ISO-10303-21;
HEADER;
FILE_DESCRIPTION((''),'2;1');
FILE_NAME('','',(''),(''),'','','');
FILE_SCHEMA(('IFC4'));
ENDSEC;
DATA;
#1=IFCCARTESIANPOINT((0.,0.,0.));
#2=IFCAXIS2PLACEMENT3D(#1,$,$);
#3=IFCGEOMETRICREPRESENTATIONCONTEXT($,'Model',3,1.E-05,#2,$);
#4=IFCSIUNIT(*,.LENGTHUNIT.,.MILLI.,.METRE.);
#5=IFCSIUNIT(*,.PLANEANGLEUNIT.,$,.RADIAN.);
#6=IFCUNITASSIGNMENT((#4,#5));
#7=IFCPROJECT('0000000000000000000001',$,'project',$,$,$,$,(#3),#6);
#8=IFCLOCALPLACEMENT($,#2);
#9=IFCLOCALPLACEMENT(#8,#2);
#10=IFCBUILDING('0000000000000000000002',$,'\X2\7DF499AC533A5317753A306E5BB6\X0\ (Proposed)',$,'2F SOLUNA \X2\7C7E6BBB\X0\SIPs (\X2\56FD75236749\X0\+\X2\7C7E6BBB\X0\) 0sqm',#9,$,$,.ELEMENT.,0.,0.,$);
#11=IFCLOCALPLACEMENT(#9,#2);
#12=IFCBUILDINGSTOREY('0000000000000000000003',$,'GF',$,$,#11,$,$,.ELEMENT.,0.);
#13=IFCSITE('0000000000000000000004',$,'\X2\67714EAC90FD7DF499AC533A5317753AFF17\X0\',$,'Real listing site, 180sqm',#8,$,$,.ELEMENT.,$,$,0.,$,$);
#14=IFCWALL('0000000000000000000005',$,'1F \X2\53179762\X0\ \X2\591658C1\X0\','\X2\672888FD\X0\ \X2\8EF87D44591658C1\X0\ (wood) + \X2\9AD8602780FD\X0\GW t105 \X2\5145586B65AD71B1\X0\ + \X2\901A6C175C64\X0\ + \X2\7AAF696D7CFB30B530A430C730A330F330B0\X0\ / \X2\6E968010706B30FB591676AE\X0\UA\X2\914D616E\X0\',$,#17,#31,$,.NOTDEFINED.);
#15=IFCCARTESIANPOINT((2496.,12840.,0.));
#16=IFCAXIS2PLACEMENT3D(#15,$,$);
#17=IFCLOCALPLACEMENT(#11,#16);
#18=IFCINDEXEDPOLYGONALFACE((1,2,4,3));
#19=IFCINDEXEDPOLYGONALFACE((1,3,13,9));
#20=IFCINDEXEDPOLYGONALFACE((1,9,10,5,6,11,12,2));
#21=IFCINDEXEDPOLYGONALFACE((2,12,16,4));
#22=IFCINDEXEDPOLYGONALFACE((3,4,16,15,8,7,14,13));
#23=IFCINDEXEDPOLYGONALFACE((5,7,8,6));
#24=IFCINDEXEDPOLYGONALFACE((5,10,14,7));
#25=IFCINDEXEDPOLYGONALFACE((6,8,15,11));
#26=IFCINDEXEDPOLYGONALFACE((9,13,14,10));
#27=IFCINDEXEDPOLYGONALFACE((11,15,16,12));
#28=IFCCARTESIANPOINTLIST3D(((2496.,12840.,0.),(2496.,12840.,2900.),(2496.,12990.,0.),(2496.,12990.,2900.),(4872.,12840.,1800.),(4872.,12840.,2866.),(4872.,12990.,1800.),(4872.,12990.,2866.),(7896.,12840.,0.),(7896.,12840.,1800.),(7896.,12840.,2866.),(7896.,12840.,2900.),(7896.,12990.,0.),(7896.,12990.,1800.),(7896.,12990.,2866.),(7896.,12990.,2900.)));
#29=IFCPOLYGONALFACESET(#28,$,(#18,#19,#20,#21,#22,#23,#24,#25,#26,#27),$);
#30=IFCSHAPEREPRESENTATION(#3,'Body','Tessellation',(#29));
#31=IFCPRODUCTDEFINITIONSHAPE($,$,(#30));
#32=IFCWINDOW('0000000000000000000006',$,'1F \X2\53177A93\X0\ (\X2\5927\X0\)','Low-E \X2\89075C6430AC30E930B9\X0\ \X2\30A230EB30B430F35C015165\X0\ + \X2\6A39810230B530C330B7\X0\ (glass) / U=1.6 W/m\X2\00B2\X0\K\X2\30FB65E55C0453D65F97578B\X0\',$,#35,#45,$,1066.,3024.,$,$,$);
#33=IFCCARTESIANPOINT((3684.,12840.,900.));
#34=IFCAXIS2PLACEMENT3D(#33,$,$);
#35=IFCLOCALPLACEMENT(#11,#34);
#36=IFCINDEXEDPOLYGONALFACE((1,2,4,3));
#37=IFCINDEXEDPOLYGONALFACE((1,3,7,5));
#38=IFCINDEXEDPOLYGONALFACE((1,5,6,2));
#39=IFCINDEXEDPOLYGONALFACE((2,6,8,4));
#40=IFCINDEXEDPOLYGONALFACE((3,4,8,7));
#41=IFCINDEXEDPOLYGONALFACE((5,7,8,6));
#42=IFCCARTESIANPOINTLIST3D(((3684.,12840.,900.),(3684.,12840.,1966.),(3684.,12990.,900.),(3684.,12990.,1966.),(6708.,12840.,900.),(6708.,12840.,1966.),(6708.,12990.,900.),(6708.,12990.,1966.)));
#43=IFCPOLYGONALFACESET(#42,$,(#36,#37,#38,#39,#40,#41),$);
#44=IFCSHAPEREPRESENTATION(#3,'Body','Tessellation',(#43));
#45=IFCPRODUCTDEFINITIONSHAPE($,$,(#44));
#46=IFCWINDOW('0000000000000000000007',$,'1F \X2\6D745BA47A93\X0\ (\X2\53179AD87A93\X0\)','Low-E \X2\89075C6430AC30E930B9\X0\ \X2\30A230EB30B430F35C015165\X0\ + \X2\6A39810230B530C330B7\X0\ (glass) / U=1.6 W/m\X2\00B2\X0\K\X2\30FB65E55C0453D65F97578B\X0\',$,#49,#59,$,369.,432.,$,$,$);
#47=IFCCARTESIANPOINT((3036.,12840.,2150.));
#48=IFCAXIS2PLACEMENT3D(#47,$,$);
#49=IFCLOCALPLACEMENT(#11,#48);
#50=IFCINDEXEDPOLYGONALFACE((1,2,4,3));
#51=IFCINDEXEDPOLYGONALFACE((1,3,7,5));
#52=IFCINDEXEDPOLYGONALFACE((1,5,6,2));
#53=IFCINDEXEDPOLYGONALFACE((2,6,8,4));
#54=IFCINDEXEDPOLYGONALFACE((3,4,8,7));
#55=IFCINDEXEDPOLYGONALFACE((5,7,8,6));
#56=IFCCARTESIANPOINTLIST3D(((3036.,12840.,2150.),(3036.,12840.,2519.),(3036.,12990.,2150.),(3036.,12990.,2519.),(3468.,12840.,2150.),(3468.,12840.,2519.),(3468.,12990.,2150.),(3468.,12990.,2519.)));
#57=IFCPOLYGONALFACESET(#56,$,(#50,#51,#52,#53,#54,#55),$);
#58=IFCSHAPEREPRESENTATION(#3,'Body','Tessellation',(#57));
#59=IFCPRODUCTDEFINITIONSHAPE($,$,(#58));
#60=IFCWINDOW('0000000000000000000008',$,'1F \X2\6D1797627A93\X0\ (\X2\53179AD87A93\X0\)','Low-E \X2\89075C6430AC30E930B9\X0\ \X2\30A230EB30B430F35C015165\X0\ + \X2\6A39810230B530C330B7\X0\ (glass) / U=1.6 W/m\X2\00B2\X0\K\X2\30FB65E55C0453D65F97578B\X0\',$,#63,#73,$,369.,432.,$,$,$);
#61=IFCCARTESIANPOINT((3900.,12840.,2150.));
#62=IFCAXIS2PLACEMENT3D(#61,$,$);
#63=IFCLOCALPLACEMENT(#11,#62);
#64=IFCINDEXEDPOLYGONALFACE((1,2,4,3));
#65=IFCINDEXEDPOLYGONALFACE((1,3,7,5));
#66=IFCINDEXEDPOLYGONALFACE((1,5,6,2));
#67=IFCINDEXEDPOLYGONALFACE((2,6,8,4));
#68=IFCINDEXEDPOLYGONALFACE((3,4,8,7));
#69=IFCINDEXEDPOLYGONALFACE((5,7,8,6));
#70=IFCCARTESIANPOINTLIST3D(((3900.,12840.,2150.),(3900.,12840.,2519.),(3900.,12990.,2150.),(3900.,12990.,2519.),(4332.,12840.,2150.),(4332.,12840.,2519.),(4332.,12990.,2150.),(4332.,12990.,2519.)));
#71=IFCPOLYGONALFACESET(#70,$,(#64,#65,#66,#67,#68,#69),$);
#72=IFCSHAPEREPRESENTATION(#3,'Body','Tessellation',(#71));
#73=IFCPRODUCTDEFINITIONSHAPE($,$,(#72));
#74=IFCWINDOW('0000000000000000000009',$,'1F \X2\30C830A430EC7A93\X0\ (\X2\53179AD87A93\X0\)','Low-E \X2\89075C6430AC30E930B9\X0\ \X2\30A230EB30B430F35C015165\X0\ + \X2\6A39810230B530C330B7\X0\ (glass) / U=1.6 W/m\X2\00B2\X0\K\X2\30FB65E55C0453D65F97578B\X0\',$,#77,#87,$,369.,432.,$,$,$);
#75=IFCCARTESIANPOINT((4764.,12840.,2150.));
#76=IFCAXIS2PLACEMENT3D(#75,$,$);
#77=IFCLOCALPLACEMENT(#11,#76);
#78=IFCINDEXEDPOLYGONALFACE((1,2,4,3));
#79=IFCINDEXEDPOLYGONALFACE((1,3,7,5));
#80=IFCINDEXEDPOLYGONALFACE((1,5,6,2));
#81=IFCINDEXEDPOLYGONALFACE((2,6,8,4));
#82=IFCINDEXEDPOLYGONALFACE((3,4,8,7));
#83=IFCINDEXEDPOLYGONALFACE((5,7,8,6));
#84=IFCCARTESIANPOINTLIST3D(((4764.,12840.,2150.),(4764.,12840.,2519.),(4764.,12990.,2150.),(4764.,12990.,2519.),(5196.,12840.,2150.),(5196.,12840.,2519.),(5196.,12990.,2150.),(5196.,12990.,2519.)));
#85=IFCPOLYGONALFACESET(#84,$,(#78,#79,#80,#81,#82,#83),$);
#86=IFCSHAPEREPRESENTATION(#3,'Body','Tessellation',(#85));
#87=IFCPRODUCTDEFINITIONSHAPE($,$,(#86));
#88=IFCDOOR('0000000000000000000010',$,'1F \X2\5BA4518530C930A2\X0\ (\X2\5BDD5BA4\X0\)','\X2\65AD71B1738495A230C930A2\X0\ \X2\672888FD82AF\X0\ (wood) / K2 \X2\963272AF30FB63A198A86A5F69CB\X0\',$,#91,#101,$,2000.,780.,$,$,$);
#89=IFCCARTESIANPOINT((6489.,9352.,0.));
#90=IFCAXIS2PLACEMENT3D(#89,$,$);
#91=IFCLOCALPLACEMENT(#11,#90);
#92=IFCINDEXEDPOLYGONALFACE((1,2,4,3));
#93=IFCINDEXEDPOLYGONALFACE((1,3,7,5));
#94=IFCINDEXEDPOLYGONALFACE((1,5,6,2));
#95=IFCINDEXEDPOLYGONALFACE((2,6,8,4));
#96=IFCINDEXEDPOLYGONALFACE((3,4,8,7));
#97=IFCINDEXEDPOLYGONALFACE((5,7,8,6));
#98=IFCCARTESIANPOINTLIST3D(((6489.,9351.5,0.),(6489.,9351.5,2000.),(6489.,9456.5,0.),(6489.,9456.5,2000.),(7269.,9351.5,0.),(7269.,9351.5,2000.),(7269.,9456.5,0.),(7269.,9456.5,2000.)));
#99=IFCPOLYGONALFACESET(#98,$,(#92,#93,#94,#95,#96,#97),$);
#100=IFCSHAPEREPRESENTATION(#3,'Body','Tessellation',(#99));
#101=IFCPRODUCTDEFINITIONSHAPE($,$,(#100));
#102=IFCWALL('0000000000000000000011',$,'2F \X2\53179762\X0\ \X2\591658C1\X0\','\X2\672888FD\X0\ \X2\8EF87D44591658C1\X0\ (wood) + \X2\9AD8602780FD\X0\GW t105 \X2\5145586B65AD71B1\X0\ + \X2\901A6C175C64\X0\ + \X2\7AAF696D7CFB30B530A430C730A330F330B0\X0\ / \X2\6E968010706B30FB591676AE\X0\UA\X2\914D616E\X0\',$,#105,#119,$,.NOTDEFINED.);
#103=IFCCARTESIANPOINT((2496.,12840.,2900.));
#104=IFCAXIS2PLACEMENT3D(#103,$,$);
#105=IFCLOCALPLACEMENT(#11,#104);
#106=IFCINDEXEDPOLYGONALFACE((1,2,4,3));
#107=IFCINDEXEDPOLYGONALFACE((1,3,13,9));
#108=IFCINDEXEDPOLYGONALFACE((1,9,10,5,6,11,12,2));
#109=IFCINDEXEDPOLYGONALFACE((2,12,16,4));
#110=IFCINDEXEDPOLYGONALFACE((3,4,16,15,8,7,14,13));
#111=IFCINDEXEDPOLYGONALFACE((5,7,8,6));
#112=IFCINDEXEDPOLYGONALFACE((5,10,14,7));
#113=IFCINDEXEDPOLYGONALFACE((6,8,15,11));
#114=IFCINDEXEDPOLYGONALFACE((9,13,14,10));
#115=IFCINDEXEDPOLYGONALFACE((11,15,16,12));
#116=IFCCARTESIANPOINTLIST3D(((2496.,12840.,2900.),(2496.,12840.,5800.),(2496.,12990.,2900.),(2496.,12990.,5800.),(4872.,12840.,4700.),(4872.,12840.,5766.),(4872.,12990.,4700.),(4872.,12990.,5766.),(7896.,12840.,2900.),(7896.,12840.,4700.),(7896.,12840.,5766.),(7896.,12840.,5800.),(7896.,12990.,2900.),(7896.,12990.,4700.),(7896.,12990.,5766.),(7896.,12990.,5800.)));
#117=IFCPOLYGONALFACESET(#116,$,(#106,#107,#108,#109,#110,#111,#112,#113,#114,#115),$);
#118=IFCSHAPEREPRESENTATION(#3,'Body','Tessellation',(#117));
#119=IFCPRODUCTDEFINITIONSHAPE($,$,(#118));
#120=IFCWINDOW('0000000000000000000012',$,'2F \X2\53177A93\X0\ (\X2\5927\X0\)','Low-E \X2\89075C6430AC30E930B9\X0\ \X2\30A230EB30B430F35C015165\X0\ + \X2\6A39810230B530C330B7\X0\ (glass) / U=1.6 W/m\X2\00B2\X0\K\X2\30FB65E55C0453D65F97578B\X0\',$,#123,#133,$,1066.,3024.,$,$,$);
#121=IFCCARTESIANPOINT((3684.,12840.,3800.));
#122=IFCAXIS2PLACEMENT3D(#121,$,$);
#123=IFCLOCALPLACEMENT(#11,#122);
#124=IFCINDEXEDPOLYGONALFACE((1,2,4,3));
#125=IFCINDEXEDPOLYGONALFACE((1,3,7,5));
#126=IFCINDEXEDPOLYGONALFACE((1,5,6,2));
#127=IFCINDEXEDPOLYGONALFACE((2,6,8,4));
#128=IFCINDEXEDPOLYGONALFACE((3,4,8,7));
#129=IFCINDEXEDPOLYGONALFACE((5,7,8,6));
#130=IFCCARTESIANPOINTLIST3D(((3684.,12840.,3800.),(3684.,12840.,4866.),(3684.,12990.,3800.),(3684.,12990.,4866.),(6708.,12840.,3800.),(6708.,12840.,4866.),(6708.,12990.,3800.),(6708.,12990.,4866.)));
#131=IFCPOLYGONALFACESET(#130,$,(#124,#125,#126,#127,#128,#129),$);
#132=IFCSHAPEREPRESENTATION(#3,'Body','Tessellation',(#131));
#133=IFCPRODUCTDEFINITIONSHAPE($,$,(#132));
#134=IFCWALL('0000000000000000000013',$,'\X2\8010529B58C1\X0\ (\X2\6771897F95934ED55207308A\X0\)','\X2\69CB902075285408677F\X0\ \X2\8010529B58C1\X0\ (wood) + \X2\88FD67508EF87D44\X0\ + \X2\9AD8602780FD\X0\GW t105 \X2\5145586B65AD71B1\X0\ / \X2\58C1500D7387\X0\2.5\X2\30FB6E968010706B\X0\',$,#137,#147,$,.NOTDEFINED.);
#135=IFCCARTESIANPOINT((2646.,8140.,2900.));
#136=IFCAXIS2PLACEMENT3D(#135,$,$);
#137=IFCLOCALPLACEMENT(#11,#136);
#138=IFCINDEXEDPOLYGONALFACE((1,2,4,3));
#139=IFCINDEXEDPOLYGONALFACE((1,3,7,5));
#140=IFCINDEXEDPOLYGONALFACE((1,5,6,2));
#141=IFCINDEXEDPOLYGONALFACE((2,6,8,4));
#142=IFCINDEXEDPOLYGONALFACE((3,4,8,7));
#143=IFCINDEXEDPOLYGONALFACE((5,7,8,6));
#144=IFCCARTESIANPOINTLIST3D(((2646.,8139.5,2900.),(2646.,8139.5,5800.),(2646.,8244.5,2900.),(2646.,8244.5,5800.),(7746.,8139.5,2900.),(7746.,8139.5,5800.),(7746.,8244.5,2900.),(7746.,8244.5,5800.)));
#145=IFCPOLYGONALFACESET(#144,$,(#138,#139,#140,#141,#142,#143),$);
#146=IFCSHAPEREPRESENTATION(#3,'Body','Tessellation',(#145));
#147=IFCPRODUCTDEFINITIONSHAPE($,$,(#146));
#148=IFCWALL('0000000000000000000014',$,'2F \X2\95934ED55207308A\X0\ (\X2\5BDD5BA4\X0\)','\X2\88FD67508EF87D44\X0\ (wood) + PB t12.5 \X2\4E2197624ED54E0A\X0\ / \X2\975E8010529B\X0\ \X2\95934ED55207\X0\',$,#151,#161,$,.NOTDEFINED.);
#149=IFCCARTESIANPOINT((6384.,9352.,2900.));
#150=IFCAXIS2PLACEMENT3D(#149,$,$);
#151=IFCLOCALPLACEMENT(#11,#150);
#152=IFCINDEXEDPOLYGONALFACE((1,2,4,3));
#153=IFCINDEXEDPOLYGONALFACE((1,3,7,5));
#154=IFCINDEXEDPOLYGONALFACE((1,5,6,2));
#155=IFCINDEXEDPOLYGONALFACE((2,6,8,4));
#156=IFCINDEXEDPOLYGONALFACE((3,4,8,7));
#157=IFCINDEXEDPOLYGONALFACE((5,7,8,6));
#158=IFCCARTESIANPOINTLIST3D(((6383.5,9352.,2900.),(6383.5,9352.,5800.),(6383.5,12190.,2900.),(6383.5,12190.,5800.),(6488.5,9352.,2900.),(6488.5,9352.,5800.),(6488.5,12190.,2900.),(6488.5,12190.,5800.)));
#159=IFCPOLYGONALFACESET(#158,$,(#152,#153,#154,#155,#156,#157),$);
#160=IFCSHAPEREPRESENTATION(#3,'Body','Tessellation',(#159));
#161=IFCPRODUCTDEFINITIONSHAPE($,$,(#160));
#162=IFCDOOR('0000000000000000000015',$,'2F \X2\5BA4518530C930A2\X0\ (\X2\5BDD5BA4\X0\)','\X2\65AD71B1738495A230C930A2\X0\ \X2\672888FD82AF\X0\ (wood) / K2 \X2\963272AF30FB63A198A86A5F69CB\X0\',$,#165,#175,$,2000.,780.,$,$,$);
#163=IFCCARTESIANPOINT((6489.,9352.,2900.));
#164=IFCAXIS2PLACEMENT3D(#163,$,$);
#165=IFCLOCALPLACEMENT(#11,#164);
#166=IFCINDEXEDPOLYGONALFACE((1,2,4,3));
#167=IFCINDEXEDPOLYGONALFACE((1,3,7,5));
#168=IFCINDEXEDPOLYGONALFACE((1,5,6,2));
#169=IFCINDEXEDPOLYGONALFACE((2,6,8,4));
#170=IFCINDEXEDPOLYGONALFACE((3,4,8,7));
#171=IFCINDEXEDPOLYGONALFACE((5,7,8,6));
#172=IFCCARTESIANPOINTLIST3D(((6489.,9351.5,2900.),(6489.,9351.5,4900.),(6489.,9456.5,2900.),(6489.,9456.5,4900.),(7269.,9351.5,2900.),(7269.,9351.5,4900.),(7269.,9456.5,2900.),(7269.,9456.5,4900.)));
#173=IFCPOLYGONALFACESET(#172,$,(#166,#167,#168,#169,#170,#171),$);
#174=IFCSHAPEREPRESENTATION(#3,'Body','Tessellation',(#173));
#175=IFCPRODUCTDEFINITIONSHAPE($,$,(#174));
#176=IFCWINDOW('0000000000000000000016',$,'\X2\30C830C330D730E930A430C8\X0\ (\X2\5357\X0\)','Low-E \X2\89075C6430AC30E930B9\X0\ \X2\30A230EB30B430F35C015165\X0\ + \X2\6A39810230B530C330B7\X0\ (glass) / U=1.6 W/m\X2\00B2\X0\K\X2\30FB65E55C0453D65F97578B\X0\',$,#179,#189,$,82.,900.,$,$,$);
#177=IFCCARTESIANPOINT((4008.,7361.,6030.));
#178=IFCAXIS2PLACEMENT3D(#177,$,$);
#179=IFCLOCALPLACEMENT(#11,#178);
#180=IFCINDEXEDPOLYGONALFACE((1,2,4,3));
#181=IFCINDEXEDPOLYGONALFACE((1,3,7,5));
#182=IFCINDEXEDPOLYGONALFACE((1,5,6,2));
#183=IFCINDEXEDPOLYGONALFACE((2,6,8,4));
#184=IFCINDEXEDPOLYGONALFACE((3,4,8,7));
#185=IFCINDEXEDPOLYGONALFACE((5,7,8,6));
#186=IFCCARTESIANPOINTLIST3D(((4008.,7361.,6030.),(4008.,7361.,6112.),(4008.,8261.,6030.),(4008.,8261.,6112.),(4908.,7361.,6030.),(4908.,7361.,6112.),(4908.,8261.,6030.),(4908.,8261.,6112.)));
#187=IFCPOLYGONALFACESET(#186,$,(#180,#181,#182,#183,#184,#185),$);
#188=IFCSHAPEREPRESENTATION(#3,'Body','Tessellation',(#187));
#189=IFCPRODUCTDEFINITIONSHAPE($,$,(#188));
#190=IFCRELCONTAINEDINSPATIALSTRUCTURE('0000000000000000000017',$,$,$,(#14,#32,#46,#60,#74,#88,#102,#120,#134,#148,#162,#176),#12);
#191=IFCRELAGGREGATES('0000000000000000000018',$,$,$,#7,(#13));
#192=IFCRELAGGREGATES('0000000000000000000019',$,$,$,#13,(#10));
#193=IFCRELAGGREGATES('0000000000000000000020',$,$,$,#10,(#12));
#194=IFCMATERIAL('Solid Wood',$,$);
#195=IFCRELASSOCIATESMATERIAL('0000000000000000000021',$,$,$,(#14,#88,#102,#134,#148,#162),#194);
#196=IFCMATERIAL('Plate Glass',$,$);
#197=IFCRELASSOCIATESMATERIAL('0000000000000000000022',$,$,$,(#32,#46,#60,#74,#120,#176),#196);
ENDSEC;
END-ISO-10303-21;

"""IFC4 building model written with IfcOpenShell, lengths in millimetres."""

from ifc_helpers import new_model, si_unit, frame, frame_2d, origin, place, context, project, spatial, rectangle, extrude, material, element, fill, save


model = new_model("IFC4")

# Units and contexts
model_context = context("Model", 3, precision=1e-05, world=origin())
ifc_project = project(units=[si_unit("LENGTHUNIT", "METRE", prefix="MILLI"), si_unit("PLANEANGLEUNIT", "RADIAN")], contexts=[model_context])

# Site, building, storey
site_placement = place(None, origin())
site = spatial("IfcSite", under=ifc_project, at=site_placement, Name="東京都練馬区北町７", ObjectType="Real listing site, 180sqm", CompositionType="ELEMENT", RefElevation=0.0)
building_placement = place(site_placement, origin())
building = spatial("IfcBuilding", under=site, at=building_placement, Name="練馬区北町の家 (Proposed)", ObjectType="2F SOLUNA 籾殻SIPs (国産杉+籾殻) 0sqm", CompositionType="ELEMENT", ElevationOfRefHeight=0.0, ElevationOfTerrain=0.0)
storey_placement = place(building_placement, origin())
storey = spatial("IfcBuildingStorey", under=building, at=storey_placement, Name="GF", CompositionType="ELEMENT", Elevation=0.0)

# Wall, openings, windows
ifc_material_1 = material(Name="Solid Wood")
wall_1_placement = place(storey_placement, frame((2496.0, 12840.0, 0.0)))
wall_1 = element("IfcWall", 1, at=wall_1_placement, inside=storey, material=ifc_material_1, Name="1F 北面 外壁", Description="木製 軸組外壁 (wood) + 高性能GW t105 充填断熱 + 通気層 + 窯業系サイディング / 準耐火・外皮UA配慮", PredefinedType="NOTDEFINED", context=model_context, shape_type="SweptSolid", body=[
    extrude(rectangle(XDim=5400.0, YDim=150.0, at=frame_2d((2700.0, 75.0))), frame((2496.0, 12840.0, 0.0)), (0.0, 0.0, 1.0), 2900.0),
])
opening_1_placement = place(storey_placement, frame((3684.0, 12840.0, 900.0)))
opening_1 = element("IfcOpeningElement", 2, at=opening_1_placement, cuts=wall_1, PredefinedType="NOTDEFINED", context=model_context, shape_type="SweptSolid", body=[
    extrude(rectangle(XDim=3024.0, YDim=150.0, at=frame_2d((1512.0, 75.0))), frame((3684.0, 12840.0, 900.0)), (0.0, 0.0, 1.0), 1066.0),
])
opening_2_placement = place(storey_placement, frame((3036.0, 12840.0, 2150.0)))
opening_2 = element("IfcOpeningElement", 3, at=opening_2_placement, cuts=wall_1, PredefinedType="NOTDEFINED", context=model_context, shape_type="SweptSolid", body=[
    extrude(rectangle(XDim=432.0, YDim=150.0, at=frame_2d((216.0, 75.0))), frame((3036.0, 12840.0, 2150.0)), (0.0, 0.0, 1.0), 369.0),
])
opening_3_placement = place(storey_placement, frame((3900.0, 12840.0, 2150.0)))
opening_3 = element("IfcOpeningElement", 4, at=opening_3_placement, cuts=wall_1, PredefinedType="NOTDEFINED", context=model_context, shape_type="SweptSolid", body=[
    extrude(rectangle(XDim=432.0, YDim=150.0, at=frame_2d((216.0, 75.0))), frame((3900.0, 12840.0, 2150.0)), (0.0, 0.0, 1.0), 369.0),
])
opening_4_placement = place(storey_placement, frame((4764.0, 12840.0, 2150.0)))
opening_4 = element("IfcOpeningElement", 5, at=opening_4_placement, cuts=wall_1, PredefinedType="NOTDEFINED", context=model_context, shape_type="SweptSolid", body=[
    extrude(rectangle(XDim=432.0, YDim=150.0, at=frame_2d((216.0, 75.0))), frame((4764.0, 12840.0, 2150.0)), (0.0, 0.0, 1.0), 369.0),
])
ifc_material_2 = material(Name="Plate Glass")
window_1_placement = place(storey_placement, frame((3684.0, 12840.0, 900.0)))
window_1 = element("IfcWindow", 6, at=window_1_placement, inside=storey, material=ifc_material_2, Name="1F 北窓 (大)", Description="Low-E 複層ガラス アルゴン封入 + 樹脂サッシ (glass) / U=1.6 W/m²K・日射取得型", OverallHeight=1066.0, OverallWidth=3024.0, context=model_context, shape_type="SweptSolid", body=[
    extrude(rectangle(XDim=3024.0, YDim=150.0, at=frame_2d((1512.0, 75.0))), frame((3684.0, 12840.0, 900.0)), (0.0, 0.0, 1.0), 1066.0),
])
fill(opening_1, window_1)
window_2_placement = place(storey_placement, frame((3036.0, 12840.0, 2150.0)))
window_2 = element("IfcWindow", 7, at=window_2_placement, inside=storey, material=ifc_material_2, Name="1F 浴室窓 (北高窓)", Description="Low-E 複層ガラス アルゴン封入 + 樹脂サッシ (glass) / U=1.6 W/m²K・日射取得型", OverallHeight=369.0, OverallWidth=432.0, context=model_context, shape_type="SweptSolid", body=[
    extrude(rectangle(XDim=432.0, YDim=150.0, at=frame_2d((216.0, 75.0))), frame((3036.0, 12840.0, 2150.0)), (0.0, 0.0, 1.0), 369.0),
])
fill(opening_2, window_2)
window_3_placement = place(storey_placement, frame((3900.0, 12840.0, 2150.0)))
window_3 = element("IfcWindow", 8, at=window_3_placement, inside=storey, material=ifc_material_2, Name="1F 洗面窓 (北高窓)", Description="Low-E 複層ガラス アルゴン封入 + 樹脂サッシ (glass) / U=1.6 W/m²K・日射取得型", OverallHeight=369.0, OverallWidth=432.0, context=model_context, shape_type="SweptSolid", body=[
    extrude(rectangle(XDim=432.0, YDim=150.0, at=frame_2d((216.0, 75.0))), frame((3900.0, 12840.0, 2150.0)), (0.0, 0.0, 1.0), 369.0),
])
fill(opening_3, window_3)
window_4_placement = place(storey_placement, frame((4764.0, 12840.0, 2150.0)))
window_4 = element("IfcWindow", 9, at=window_4_placement, inside=storey, material=ifc_material_2, Name="1F トイレ窓 (北高窓)", Description="Low-E 複層ガラス アルゴン封入 + 樹脂サッシ (glass) / U=1.6 W/m²K・日射取得型", OverallHeight=369.0, OverallWidth=432.0, context=model_context, shape_type="SweptSolid", body=[
    extrude(rectangle(XDim=432.0, YDim=150.0, at=frame_2d((216.0, 75.0))), frame((4764.0, 12840.0, 2150.0)), (0.0, 0.0, 1.0), 369.0),
])
fill(opening_4, window_4)

# Door
door_1_placement = place(storey_placement, frame((6489.0, 9352.0, 0.0)))
element("IfcDoor", 10, at=door_1_placement, inside=storey, material=ifc_material_1, Name="1F 室内ドア (寝室)", Description="断熱玄関ドア 木製芯 (wood) / K2 防犯・採風機構", OverallHeight=2000.0, OverallWidth=780.0, context=model_context, shape_type="SweptSolid", body=[
    extrude(rectangle(XDim=780.0, YDim=105.0, at=frame_2d((390.0, 52.0))), frame((6489.0, 9352.0, 0.0)), (0.0, 0.0, 1.0), 2000.0),
])

# Wall, opening, window
wall_2_placement = place(storey_placement, frame((2496.0, 12840.0, 2900.0)))
wall_2 = element("IfcWall", 11, at=wall_2_placement, inside=storey, material=ifc_material_1, Name="2F 北面 外壁", Description="木製 軸組外壁 (wood) + 高性能GW t105 充填断熱 + 通気層 + 窯業系サイディング / 準耐火・外皮UA配慮", PredefinedType="NOTDEFINED", context=model_context, shape_type="SweptSolid", body=[
    extrude(rectangle(XDim=5400.0, YDim=150.0, at=frame_2d((2700.0, 75.0))), frame((2496.0, 12840.0, 2900.0)), (0.0, 0.0, 1.0), 2900.0),
])
opening_5_placement = place(storey_placement, frame((3684.0, 12840.0, 3800.0)))
opening_5 = element("IfcOpeningElement", 12, at=opening_5_placement, cuts=wall_2, PredefinedType="NOTDEFINED", context=model_context, shape_type="SweptSolid", body=[
    extrude(rectangle(XDim=3024.0, YDim=150.0, at=frame_2d((1512.0, 75.0))), frame((3684.0, 12840.0, 3800.0)), (0.0, 0.0, 1.0), 1066.0),
])
window_5_placement = place(storey_placement, frame((3684.0, 12840.0, 3800.0)))
window_5 = element("IfcWindow", 13, at=window_5_placement, inside=storey, material=ifc_material_2, Name="2F 北窓 (大)", Description="Low-E 複層ガラス アルゴン封入 + 樹脂サッシ (glass) / U=1.6 W/m²K・日射取得型", OverallHeight=1066.0, OverallWidth=3024.0, context=model_context, shape_type="SweptSolid", body=[
    extrude(rectangle(XDim=3024.0, YDim=150.0, at=frame_2d((1512.0, 75.0))), frame((3684.0, 12840.0, 3800.0)), (0.0, 0.0, 1.0), 1066.0),
])
fill(opening_5, window_5)

# Walls
wall_3_placement = place(storey_placement, frame((2646.0, 8140.0, 2900.0)))
element("IfcWall", 14, at=wall_3_placement, inside=storey, material=ifc_material_1, Name="耐力壁 (東西間仕切り)", Description="構造用合板 耐力壁 (wood) + 製材軸組 + 高性能GW t105 充填断熱 / 壁倍率2.5・準耐火", PredefinedType="NOTDEFINED", context=model_context, shape_type="SweptSolid", body=[
    extrude(rectangle(XDim=5100.0, YDim=105.0, at=frame_2d((2550.0, 52.0))), frame((2646.0, 8140.0, 2900.0)), (0.0, 0.0, 1.0), 2900.0),
])
wall_4_placement = place(storey_placement, frame((6384.0, 9352.0, 2900.0)))
element("IfcWall", 15, at=wall_4_placement, inside=storey, material=ifc_material_1, Name="2F 間仕切り (寝室)", Description="製材軸組 (wood) + PB t12.5 両面仕上 / 非耐力 間仕切", PredefinedType="NOTDEFINED", context=model_context, shape_type="SweptSolid", body=[
    extrude(rectangle(XDim=105.0, YDim=2838.0, at=frame_2d((52.0, 1419.0))), frame((6384.0, 9352.0, 2900.0)), (0.0, 0.0, 1.0), 2900.0),
])

# Door
door_2_placement = place(storey_placement, frame((6489.0, 9352.0, 2900.0)))
element("IfcDoor", 16, at=door_2_placement, inside=storey, material=ifc_material_1, Name="2F 室内ドア (寝室)", Description="断熱玄関ドア 木製芯 (wood) / K2 防犯・採風機構", OverallHeight=2000.0, OverallWidth=780.0, context=model_context, shape_type="SweptSolid", body=[
    extrude(rectangle(XDim=780.0, YDim=105.0, at=frame_2d((390.0, 52.0))), frame((6489.0, 9352.0, 2900.0)), (0.0, 0.0, 1.0), 2000.0),
])

# Window
window_6_placement = place(storey_placement, frame((4008.0, 7361.0, 6030.0)))
element("IfcWindow", 17, at=window_6_placement, inside=storey, material=ifc_material_2, Name="トップライト (南)", Description="Low-E 複層ガラス アルゴン封入 + 樹脂サッシ (glass) / U=1.6 W/m²K・日射取得型", OverallHeight=82.0, OverallWidth=900.0, context=model_context, shape_type="SweptSolid", body=[
    extrude(rectangle(XDim=900.0, YDim=900.0, at=frame_2d((450.0, 450.0))), frame((4008.0, 7361.0, 6030.0)), (0.0, 0.0, 1.0), 82.0),
])

save(model, "model.ifc")
